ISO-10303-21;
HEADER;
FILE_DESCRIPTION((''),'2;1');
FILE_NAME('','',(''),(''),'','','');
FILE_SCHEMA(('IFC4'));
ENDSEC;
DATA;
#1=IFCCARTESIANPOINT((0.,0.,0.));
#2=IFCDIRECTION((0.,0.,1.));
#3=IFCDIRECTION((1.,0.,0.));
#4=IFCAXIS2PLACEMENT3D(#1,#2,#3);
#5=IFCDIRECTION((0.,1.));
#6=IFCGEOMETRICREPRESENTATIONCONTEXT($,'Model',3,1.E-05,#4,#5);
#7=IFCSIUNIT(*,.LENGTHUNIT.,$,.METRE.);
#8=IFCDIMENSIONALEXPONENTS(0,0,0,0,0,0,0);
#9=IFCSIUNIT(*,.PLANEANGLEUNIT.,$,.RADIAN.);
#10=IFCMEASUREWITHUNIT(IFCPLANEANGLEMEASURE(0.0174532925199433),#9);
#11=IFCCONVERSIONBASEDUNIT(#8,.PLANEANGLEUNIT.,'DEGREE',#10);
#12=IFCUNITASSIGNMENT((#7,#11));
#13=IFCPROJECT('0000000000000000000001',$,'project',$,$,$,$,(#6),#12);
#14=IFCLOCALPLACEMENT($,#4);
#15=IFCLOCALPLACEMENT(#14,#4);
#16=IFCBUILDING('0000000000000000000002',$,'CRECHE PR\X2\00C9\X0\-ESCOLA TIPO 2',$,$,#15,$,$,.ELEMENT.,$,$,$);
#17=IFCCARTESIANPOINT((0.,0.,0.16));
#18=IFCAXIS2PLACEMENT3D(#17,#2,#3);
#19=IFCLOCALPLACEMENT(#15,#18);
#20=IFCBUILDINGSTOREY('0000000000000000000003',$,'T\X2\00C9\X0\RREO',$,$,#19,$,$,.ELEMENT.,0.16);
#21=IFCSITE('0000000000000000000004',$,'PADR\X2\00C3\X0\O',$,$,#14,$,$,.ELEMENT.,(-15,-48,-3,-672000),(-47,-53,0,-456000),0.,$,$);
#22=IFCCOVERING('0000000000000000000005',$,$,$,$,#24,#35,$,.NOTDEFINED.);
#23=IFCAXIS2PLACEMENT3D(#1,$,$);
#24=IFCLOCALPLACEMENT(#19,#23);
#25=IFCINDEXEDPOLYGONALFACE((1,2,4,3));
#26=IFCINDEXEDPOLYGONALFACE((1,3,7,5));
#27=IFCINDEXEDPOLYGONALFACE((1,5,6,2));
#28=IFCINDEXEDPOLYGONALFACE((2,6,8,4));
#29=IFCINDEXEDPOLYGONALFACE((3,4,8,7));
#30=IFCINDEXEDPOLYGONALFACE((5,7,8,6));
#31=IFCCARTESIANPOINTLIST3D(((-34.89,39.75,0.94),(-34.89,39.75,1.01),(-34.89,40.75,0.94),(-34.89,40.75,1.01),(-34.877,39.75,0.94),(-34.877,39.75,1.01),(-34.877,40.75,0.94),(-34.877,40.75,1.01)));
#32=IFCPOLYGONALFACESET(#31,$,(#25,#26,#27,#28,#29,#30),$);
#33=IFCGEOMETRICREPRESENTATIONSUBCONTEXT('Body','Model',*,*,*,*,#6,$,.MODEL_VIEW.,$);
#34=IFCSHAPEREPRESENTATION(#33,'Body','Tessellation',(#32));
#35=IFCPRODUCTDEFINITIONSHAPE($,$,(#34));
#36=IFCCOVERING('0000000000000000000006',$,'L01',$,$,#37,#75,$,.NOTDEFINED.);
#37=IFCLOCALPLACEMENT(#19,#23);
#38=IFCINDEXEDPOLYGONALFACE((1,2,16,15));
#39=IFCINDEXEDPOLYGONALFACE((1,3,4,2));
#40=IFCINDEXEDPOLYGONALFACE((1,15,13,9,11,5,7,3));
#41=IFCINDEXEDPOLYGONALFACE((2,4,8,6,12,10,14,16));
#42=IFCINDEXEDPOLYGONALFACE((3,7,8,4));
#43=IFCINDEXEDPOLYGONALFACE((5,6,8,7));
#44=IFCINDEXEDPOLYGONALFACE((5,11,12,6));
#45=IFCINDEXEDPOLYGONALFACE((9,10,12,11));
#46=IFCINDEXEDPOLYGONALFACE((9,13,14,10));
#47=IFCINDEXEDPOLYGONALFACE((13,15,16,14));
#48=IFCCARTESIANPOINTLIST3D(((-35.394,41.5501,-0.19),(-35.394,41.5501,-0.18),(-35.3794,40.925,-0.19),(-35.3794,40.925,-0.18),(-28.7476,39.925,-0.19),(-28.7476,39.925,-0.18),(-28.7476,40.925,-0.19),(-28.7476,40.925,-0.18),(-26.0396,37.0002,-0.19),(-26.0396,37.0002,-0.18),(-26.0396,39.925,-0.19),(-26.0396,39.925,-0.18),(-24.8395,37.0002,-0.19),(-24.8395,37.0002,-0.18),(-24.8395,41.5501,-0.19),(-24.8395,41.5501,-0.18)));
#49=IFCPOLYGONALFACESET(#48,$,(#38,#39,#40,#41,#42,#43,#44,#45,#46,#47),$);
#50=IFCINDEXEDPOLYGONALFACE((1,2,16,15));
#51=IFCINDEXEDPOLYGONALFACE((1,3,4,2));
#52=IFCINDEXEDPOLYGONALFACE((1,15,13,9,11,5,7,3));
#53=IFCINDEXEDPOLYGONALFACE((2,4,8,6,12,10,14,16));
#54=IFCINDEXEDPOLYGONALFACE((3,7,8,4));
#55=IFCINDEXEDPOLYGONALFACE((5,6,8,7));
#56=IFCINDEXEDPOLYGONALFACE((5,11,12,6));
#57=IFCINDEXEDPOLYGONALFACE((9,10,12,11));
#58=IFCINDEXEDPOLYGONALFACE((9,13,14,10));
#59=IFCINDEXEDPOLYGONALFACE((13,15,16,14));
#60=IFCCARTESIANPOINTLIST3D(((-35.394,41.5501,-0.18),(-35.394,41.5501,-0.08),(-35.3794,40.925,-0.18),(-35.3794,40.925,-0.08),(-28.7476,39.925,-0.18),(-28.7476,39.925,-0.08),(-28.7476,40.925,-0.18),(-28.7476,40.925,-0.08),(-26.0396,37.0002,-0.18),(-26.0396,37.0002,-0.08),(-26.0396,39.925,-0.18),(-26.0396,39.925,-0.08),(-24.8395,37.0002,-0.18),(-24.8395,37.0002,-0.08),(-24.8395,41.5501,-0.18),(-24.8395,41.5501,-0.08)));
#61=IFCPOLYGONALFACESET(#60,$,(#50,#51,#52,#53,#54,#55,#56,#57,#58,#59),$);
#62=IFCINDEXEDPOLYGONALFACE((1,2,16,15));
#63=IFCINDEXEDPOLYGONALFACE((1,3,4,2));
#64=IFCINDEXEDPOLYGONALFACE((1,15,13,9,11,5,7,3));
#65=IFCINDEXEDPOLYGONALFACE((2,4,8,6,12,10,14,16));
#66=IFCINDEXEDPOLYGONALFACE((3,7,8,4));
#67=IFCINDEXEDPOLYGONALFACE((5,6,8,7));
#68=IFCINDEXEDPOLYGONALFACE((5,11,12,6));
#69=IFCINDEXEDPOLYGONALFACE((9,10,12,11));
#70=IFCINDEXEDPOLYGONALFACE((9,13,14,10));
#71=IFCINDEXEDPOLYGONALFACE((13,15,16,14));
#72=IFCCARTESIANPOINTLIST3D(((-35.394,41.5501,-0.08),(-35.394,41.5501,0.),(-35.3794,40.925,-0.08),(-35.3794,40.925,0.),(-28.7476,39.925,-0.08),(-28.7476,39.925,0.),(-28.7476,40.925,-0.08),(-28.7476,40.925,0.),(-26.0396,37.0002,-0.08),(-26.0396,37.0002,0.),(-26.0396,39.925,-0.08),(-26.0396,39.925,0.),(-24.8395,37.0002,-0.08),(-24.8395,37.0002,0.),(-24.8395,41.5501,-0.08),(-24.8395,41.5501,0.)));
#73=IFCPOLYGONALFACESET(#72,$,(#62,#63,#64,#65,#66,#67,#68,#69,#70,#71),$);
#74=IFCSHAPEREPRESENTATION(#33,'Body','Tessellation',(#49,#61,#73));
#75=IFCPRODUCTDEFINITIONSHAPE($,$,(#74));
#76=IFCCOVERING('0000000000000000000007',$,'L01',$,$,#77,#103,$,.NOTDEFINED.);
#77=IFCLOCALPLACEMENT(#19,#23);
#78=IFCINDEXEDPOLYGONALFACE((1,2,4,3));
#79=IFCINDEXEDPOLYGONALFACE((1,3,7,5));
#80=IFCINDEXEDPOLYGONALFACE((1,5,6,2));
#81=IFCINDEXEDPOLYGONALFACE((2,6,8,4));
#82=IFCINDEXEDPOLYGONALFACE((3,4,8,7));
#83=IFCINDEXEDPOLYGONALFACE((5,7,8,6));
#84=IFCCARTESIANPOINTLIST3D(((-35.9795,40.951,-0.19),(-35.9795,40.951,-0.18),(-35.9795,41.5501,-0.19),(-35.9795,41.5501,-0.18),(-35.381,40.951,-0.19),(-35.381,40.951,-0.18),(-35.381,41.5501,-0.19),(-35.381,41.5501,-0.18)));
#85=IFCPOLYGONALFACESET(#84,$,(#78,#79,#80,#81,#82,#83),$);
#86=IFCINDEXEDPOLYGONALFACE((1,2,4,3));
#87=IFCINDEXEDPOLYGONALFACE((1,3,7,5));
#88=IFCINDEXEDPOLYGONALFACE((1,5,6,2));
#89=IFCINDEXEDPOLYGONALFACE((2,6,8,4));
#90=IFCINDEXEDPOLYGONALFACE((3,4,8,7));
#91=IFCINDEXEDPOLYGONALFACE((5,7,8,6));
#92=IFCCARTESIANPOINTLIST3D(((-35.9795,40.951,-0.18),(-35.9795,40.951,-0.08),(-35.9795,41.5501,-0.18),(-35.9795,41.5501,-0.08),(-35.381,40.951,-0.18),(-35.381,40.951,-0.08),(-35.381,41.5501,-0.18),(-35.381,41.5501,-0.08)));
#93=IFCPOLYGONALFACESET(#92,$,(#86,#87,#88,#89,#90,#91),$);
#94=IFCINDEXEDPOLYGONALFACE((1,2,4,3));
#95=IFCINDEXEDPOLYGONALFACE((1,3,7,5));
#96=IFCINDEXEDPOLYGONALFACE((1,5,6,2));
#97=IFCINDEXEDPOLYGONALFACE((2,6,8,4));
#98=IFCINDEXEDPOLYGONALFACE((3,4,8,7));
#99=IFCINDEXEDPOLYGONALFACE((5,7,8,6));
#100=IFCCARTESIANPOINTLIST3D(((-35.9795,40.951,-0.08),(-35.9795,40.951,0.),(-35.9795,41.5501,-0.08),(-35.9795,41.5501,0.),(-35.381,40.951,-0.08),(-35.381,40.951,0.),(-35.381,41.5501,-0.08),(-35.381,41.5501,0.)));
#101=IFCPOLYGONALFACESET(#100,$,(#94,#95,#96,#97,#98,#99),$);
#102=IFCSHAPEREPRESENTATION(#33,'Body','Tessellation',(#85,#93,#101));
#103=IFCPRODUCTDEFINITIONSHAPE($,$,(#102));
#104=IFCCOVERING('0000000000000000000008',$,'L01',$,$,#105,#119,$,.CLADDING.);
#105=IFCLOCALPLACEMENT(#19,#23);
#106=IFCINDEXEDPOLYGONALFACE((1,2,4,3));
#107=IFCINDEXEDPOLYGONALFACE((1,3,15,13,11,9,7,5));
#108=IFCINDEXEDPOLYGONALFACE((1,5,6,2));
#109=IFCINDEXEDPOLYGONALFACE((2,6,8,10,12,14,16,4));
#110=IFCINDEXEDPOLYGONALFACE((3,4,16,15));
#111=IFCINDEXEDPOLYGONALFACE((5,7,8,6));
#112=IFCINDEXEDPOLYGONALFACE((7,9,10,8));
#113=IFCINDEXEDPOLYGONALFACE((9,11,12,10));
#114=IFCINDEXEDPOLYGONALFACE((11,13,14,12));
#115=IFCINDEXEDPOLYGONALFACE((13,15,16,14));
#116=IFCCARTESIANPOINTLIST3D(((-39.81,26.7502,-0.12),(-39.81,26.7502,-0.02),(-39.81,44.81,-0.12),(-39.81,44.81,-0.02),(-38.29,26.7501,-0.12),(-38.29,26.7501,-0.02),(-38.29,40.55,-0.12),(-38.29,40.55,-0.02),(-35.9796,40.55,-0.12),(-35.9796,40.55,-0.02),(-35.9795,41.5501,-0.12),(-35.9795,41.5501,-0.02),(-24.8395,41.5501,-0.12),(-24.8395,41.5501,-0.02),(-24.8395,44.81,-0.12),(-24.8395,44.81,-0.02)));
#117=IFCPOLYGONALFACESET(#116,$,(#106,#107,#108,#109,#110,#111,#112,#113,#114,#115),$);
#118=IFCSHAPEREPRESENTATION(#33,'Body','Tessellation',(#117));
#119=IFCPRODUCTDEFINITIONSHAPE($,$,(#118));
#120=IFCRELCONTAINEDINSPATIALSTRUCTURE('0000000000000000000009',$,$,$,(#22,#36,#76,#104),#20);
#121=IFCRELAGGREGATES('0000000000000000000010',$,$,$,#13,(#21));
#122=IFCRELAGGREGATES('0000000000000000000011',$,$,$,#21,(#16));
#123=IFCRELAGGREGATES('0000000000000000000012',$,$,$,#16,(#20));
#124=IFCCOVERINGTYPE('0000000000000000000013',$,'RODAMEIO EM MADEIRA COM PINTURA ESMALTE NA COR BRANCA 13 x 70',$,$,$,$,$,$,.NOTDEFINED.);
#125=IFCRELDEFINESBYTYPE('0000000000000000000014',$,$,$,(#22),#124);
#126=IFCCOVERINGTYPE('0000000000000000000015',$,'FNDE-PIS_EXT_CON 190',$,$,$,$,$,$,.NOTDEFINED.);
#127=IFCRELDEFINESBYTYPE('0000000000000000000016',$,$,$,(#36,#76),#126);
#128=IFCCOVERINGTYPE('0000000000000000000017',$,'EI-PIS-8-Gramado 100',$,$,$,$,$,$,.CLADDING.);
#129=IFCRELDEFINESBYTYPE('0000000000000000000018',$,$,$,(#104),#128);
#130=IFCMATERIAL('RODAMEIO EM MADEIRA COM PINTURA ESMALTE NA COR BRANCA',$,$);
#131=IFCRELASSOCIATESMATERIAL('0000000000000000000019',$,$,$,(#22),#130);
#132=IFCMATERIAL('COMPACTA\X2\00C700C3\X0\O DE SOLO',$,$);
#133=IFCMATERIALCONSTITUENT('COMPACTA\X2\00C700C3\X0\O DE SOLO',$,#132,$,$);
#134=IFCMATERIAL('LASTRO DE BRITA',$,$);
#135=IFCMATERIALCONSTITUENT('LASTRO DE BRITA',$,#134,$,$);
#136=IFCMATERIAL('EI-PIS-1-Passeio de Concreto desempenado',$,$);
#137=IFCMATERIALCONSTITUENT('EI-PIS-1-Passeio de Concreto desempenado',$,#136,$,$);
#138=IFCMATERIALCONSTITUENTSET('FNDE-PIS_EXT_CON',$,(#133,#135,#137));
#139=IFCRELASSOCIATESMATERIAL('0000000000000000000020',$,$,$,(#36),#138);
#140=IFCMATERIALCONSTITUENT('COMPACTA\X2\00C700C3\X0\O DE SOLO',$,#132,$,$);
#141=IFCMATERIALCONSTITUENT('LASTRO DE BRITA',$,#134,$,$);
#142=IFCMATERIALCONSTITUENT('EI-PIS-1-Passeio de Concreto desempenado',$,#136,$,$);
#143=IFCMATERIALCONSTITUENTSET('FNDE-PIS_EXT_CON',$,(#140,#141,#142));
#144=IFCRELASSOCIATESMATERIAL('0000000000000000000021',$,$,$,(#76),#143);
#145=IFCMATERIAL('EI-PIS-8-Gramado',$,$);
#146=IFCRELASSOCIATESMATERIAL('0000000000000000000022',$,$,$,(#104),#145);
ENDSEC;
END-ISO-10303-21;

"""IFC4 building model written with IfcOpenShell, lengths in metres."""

from ifc_helpers import new_model, entity, si_unit, converted_unit, direction, frame, frame_2d, origin_with_axes, place, context, subcontext, project, spatial, line, indexed_curve, rectangle, outline, extrude, material, constituent, constituent_set, type_object, element, save


model = new_model("IFC4")

# Units and contexts
model_context = context("Model", 3, precision=1e-05, world=origin_with_axes(), true_north=direction((0.0, 1.0)))
body_context = subcontext(model_context, "Body", "Model", "MODEL_VIEW")
ifc_project = project(units=[si_unit("LENGTHUNIT", "METRE"), converted_unit("PLANEANGLEUNIT", "DEGREE", entity("IfcPlaneAngleMeasure", 0.0174532925199433), si_unit("PLANEANGLEUNIT", "RADIAN"), dimensions=[0, 0, 0, 0, 0, 0, 0])], contexts=[model_context])

# Site, building, storey
site_placement = place(None, origin_with_axes())
site = spatial("IfcSite", under=ifc_project, at=site_placement, Name="PADRÃO", CompositionType="ELEMENT", RefLatitude=(-15, -48, -3, -672000), RefLongitude=(-47, -53, 0, -456000), RefElevation=0.0)
building_placement = place(site_placement, origin_with_axes())
building = spatial("IfcBuilding", under=site, at=building_placement, Name="CRECHE PRÉ-ESCOLA TIPO 2", CompositionType="ELEMENT")
storey_placement = place(building_placement, frame((0.0, 0.0, 0.16), z_axis=(0.0, 0.0, 1.0), x_axis=(1.0, 0.0, 0.0)))
storey = spatial("IfcBuildingStorey", under=building, at=storey_placement, Name="TÉRREO", CompositionType="ELEMENT", Elevation=0.16)

# Coverings
ifc_material_1 = material(Name="RODAMEIO EM MADEIRA COM PINTURA ESMALTE NA COR BRANCA")
covering_type_1 = type_object("IfcCoveringType", Name="RODAMEIO EM MADEIRA COM PINTURA ESMALTE NA COR BRANCA 13 x 70", PredefinedType="NOTDEFINED")
covering_1_placement = place(storey_placement, frame((-34.89, 40.75, 0.94), z_axis=(0.0, 0.0, 1.0), x_axis=(-1.0, 0.0, 0.0)))
element("IfcCovering", 1, at=covering_1_placement, inside=storey, type_object=covering_type_1, material=ifc_material_1, PredefinedType="NOTDEFINED", context=body_context, shape_type="SweptSolid", body=[
    extrude(rectangle(XDim=0.07, YDim=0.013, at=frame_2d((0.035, -0.0065), x_axis=(1.0, 0.0))), frame((0.0, 0.0, 0.0), z_axis=(0.0, 1.0, 0.0), x_axis=(0.0, 0.0, 1.0)), (0.0, 0.0, 1.0), 1.0),
])
ifc_material_2 = material(Name="COMPACTAÇÃO DE SOLO")
ifc_constituent_1 = constituent(ifc_material_2, Name="COMPACTAÇÃO DE SOLO")
ifc_material_3 = material(Name="LASTRO DE BRITA")
ifc_constituent_2 = constituent(ifc_material_3, Name="LASTRO DE BRITA")
ifc_material_4 = material(Name="EI-PIS-1-Passeio de Concreto desempenado")
ifc_constituent_3 = constituent(ifc_material_4, Name="EI-PIS-1-Passeio de Concreto desempenado")
ifc_constituent_set_1 = constituent_set(constituents=[ifc_constituent_1, ifc_constituent_2, ifc_constituent_3], Name="FNDE-PIS_EXT_CON")
covering_type_2 = type_object("IfcCoveringType", Name="FNDE-PIS_EXT_CON 190", PredefinedType="NOTDEFINED")
covering_2_placement = place(storey_placement, frame((-35.3794, 40.925, 0.0), z_axis=(0.0, 0.0, 1.0), x_axis=(1.0, 0.0, 0.0)))
element("IfcCovering", 2, at=covering_2_placement, inside=storey, type_object=covering_type_2, material=ifc_constituent_set_1, Name="L01", PredefinedType="NOTDEFINED", context=body_context, shape_type="SweptSolid", body=[
    extrude(outline(indexed_curve([(0.0, 0.0), (6.6318, 0.0), (6.6318, -1.0), (9.3399, -1.0), (9.3398, -3.9248), (10.5399, -3.9248), (10.5399, 0.6251), (-0.0146, 0.6251)], segments=[line(1, 2, 3, 4, 5, 6, 7, 8, 1)])), frame((0.0, 0.0, -0.19), z_axis=(0.0, 0.0, 1.0), x_axis=(1.0, 0.0, 0.0)), (0.0, 0.0, 1.0), 0.01),
    extrude(outline(indexed_curve([(0.0, 0.0), (6.6318, 0.0), (6.6318, -1.0), (9.3399, -1.0), (9.3398, -3.9248), (10.5399, -3.9248), (10.5399, 0.6251), (-0.0146, 0.6251)], segments=[line(1, 2, 3, 4, 5, 6, 7, 8, 1)])), frame((0.0, 0.0, -0.18), z_axis=(0.0, 0.0, 1.0), x_axis=(1.0, 0.0, 0.0)), (0.0, 0.0, 1.0), 0.1),
    extrude(outline(indexed_curve([(0.0, 0.0), (6.6318, 0.0), (6.6318, -1.0), (9.3399, -1.0), (9.3398, -3.9248), (10.5399, -3.9248), (10.5399, 0.6251), (-0.0146, 0.6251)], segments=[line(1, 2, 3, 4, 5, 6, 7, 8, 1)])), frame((0.0, 0.0, -0.08), z_axis=(0.0, 0.0, 1.0), x_axis=(1.0, 0.0, 0.0)), (0.0, 0.0, 1.0), 0.08),
])
ifc_constituent_4 = constituent(ifc_material_2, Name="COMPACTAÇÃO DE SOLO")
ifc_constituent_5 = constituent(ifc_material_3, Name="LASTRO DE BRITA")
ifc_constituent_6 = constituent(ifc_material_4, Name="EI-PIS-1-Passeio de Concreto desempenado")
ifc_constituent_set_2 = constituent_set(constituents=[ifc_constituent_4, ifc_constituent_5, ifc_constituent_6], Name="FNDE-PIS_EXT_CON")
covering_3_placement = place(storey_placement, frame((-35.9795, 40.951, 0.0), z_axis=(0.0, 0.0, 1.0), x_axis=(1.0, 0.0, 0.0)))
element("IfcCovering", 3, at=covering_3_placement, inside=storey, type_object=covering_type_2, material=ifc_constituent_set_2, Name="L01", PredefinedType="NOTDEFINED", context=body_context, shape_type="SweptSolid", body=[
    extrude(outline(indexed_curve([(0.0, 0.0), (0.5985, 0.0), (0.5985, 0.5991), (0.0, 0.5991)], segments=[line(1, 2, 3, 4, 1)])), frame((0.0, 0.0, -0.19), z_axis=(0.0, 0.0, 1.0), x_axis=(1.0, 0.0, 0.0)), (0.0, 0.0, 1.0), 0.01),
    extrude(outline(indexed_curve([(0.0, 0.0), (0.5985, 0.0), (0.5985, 0.5991), (0.0, 0.5991)], segments=[line(1, 2, 3, 4, 1)])), frame((0.0, 0.0, -0.18), z_axis=(0.0, 0.0, 1.0), x_axis=(1.0, 0.0, 0.0)), (0.0, 0.0, 1.0), 0.1),
    extrude(outline(indexed_curve([(0.0, 0.0), (0.5985, 0.0), (0.5985, 0.5991), (0.0, 0.5991)], segments=[line(1, 2, 3, 4, 1)])), frame((0.0, 0.0, -0.08), z_axis=(0.0, 0.0, 1.0), x_axis=(1.0, 0.0, 0.0)), (0.0, 0.0, 1.0), 0.08),
])
ifc_material_5 = material(Name="EI-PIS-8-Gramado")
covering_type_3 = type_object("IfcCoveringType", Name="EI-PIS-8-Gramado 100", PredefinedType="CLADDING")
covering_4_placement = place(storey_placement, frame((-39.81, 44.81, -0.02), z_axis=(0.0, 0.0, 1.0), x_axis=(1.0, 0.0, 0.0)))
element("IfcCovering", 4, at=covering_4_placement, inside=storey, type_object=covering_type_3, material=ifc_material_5, Name="L01", PredefinedType="CLADDING", context=body_context, shape_type="SweptSolid", body=[
    extrude(outline(indexed_curve([(0.0, 0.0), (0.0, -18.0598), (1.52, -18.0599), (1.52, -4.26), (3.8304, -4.26), (3.8305, -3.2599), (14.9705, -3.2599), (14.9705, 0.0)], segments=[line(1, 2, 3, 4, 5, 6, 7, 8, 1)])), frame((0.0, 0.0, -0.1), z_axis=(0.0, 0.0, 1.0), x_axis=(1.0, 0.0, 0.0)), (0.0, 0.0, 1.0), 0.1),
])

save(model, "model.ifc")
